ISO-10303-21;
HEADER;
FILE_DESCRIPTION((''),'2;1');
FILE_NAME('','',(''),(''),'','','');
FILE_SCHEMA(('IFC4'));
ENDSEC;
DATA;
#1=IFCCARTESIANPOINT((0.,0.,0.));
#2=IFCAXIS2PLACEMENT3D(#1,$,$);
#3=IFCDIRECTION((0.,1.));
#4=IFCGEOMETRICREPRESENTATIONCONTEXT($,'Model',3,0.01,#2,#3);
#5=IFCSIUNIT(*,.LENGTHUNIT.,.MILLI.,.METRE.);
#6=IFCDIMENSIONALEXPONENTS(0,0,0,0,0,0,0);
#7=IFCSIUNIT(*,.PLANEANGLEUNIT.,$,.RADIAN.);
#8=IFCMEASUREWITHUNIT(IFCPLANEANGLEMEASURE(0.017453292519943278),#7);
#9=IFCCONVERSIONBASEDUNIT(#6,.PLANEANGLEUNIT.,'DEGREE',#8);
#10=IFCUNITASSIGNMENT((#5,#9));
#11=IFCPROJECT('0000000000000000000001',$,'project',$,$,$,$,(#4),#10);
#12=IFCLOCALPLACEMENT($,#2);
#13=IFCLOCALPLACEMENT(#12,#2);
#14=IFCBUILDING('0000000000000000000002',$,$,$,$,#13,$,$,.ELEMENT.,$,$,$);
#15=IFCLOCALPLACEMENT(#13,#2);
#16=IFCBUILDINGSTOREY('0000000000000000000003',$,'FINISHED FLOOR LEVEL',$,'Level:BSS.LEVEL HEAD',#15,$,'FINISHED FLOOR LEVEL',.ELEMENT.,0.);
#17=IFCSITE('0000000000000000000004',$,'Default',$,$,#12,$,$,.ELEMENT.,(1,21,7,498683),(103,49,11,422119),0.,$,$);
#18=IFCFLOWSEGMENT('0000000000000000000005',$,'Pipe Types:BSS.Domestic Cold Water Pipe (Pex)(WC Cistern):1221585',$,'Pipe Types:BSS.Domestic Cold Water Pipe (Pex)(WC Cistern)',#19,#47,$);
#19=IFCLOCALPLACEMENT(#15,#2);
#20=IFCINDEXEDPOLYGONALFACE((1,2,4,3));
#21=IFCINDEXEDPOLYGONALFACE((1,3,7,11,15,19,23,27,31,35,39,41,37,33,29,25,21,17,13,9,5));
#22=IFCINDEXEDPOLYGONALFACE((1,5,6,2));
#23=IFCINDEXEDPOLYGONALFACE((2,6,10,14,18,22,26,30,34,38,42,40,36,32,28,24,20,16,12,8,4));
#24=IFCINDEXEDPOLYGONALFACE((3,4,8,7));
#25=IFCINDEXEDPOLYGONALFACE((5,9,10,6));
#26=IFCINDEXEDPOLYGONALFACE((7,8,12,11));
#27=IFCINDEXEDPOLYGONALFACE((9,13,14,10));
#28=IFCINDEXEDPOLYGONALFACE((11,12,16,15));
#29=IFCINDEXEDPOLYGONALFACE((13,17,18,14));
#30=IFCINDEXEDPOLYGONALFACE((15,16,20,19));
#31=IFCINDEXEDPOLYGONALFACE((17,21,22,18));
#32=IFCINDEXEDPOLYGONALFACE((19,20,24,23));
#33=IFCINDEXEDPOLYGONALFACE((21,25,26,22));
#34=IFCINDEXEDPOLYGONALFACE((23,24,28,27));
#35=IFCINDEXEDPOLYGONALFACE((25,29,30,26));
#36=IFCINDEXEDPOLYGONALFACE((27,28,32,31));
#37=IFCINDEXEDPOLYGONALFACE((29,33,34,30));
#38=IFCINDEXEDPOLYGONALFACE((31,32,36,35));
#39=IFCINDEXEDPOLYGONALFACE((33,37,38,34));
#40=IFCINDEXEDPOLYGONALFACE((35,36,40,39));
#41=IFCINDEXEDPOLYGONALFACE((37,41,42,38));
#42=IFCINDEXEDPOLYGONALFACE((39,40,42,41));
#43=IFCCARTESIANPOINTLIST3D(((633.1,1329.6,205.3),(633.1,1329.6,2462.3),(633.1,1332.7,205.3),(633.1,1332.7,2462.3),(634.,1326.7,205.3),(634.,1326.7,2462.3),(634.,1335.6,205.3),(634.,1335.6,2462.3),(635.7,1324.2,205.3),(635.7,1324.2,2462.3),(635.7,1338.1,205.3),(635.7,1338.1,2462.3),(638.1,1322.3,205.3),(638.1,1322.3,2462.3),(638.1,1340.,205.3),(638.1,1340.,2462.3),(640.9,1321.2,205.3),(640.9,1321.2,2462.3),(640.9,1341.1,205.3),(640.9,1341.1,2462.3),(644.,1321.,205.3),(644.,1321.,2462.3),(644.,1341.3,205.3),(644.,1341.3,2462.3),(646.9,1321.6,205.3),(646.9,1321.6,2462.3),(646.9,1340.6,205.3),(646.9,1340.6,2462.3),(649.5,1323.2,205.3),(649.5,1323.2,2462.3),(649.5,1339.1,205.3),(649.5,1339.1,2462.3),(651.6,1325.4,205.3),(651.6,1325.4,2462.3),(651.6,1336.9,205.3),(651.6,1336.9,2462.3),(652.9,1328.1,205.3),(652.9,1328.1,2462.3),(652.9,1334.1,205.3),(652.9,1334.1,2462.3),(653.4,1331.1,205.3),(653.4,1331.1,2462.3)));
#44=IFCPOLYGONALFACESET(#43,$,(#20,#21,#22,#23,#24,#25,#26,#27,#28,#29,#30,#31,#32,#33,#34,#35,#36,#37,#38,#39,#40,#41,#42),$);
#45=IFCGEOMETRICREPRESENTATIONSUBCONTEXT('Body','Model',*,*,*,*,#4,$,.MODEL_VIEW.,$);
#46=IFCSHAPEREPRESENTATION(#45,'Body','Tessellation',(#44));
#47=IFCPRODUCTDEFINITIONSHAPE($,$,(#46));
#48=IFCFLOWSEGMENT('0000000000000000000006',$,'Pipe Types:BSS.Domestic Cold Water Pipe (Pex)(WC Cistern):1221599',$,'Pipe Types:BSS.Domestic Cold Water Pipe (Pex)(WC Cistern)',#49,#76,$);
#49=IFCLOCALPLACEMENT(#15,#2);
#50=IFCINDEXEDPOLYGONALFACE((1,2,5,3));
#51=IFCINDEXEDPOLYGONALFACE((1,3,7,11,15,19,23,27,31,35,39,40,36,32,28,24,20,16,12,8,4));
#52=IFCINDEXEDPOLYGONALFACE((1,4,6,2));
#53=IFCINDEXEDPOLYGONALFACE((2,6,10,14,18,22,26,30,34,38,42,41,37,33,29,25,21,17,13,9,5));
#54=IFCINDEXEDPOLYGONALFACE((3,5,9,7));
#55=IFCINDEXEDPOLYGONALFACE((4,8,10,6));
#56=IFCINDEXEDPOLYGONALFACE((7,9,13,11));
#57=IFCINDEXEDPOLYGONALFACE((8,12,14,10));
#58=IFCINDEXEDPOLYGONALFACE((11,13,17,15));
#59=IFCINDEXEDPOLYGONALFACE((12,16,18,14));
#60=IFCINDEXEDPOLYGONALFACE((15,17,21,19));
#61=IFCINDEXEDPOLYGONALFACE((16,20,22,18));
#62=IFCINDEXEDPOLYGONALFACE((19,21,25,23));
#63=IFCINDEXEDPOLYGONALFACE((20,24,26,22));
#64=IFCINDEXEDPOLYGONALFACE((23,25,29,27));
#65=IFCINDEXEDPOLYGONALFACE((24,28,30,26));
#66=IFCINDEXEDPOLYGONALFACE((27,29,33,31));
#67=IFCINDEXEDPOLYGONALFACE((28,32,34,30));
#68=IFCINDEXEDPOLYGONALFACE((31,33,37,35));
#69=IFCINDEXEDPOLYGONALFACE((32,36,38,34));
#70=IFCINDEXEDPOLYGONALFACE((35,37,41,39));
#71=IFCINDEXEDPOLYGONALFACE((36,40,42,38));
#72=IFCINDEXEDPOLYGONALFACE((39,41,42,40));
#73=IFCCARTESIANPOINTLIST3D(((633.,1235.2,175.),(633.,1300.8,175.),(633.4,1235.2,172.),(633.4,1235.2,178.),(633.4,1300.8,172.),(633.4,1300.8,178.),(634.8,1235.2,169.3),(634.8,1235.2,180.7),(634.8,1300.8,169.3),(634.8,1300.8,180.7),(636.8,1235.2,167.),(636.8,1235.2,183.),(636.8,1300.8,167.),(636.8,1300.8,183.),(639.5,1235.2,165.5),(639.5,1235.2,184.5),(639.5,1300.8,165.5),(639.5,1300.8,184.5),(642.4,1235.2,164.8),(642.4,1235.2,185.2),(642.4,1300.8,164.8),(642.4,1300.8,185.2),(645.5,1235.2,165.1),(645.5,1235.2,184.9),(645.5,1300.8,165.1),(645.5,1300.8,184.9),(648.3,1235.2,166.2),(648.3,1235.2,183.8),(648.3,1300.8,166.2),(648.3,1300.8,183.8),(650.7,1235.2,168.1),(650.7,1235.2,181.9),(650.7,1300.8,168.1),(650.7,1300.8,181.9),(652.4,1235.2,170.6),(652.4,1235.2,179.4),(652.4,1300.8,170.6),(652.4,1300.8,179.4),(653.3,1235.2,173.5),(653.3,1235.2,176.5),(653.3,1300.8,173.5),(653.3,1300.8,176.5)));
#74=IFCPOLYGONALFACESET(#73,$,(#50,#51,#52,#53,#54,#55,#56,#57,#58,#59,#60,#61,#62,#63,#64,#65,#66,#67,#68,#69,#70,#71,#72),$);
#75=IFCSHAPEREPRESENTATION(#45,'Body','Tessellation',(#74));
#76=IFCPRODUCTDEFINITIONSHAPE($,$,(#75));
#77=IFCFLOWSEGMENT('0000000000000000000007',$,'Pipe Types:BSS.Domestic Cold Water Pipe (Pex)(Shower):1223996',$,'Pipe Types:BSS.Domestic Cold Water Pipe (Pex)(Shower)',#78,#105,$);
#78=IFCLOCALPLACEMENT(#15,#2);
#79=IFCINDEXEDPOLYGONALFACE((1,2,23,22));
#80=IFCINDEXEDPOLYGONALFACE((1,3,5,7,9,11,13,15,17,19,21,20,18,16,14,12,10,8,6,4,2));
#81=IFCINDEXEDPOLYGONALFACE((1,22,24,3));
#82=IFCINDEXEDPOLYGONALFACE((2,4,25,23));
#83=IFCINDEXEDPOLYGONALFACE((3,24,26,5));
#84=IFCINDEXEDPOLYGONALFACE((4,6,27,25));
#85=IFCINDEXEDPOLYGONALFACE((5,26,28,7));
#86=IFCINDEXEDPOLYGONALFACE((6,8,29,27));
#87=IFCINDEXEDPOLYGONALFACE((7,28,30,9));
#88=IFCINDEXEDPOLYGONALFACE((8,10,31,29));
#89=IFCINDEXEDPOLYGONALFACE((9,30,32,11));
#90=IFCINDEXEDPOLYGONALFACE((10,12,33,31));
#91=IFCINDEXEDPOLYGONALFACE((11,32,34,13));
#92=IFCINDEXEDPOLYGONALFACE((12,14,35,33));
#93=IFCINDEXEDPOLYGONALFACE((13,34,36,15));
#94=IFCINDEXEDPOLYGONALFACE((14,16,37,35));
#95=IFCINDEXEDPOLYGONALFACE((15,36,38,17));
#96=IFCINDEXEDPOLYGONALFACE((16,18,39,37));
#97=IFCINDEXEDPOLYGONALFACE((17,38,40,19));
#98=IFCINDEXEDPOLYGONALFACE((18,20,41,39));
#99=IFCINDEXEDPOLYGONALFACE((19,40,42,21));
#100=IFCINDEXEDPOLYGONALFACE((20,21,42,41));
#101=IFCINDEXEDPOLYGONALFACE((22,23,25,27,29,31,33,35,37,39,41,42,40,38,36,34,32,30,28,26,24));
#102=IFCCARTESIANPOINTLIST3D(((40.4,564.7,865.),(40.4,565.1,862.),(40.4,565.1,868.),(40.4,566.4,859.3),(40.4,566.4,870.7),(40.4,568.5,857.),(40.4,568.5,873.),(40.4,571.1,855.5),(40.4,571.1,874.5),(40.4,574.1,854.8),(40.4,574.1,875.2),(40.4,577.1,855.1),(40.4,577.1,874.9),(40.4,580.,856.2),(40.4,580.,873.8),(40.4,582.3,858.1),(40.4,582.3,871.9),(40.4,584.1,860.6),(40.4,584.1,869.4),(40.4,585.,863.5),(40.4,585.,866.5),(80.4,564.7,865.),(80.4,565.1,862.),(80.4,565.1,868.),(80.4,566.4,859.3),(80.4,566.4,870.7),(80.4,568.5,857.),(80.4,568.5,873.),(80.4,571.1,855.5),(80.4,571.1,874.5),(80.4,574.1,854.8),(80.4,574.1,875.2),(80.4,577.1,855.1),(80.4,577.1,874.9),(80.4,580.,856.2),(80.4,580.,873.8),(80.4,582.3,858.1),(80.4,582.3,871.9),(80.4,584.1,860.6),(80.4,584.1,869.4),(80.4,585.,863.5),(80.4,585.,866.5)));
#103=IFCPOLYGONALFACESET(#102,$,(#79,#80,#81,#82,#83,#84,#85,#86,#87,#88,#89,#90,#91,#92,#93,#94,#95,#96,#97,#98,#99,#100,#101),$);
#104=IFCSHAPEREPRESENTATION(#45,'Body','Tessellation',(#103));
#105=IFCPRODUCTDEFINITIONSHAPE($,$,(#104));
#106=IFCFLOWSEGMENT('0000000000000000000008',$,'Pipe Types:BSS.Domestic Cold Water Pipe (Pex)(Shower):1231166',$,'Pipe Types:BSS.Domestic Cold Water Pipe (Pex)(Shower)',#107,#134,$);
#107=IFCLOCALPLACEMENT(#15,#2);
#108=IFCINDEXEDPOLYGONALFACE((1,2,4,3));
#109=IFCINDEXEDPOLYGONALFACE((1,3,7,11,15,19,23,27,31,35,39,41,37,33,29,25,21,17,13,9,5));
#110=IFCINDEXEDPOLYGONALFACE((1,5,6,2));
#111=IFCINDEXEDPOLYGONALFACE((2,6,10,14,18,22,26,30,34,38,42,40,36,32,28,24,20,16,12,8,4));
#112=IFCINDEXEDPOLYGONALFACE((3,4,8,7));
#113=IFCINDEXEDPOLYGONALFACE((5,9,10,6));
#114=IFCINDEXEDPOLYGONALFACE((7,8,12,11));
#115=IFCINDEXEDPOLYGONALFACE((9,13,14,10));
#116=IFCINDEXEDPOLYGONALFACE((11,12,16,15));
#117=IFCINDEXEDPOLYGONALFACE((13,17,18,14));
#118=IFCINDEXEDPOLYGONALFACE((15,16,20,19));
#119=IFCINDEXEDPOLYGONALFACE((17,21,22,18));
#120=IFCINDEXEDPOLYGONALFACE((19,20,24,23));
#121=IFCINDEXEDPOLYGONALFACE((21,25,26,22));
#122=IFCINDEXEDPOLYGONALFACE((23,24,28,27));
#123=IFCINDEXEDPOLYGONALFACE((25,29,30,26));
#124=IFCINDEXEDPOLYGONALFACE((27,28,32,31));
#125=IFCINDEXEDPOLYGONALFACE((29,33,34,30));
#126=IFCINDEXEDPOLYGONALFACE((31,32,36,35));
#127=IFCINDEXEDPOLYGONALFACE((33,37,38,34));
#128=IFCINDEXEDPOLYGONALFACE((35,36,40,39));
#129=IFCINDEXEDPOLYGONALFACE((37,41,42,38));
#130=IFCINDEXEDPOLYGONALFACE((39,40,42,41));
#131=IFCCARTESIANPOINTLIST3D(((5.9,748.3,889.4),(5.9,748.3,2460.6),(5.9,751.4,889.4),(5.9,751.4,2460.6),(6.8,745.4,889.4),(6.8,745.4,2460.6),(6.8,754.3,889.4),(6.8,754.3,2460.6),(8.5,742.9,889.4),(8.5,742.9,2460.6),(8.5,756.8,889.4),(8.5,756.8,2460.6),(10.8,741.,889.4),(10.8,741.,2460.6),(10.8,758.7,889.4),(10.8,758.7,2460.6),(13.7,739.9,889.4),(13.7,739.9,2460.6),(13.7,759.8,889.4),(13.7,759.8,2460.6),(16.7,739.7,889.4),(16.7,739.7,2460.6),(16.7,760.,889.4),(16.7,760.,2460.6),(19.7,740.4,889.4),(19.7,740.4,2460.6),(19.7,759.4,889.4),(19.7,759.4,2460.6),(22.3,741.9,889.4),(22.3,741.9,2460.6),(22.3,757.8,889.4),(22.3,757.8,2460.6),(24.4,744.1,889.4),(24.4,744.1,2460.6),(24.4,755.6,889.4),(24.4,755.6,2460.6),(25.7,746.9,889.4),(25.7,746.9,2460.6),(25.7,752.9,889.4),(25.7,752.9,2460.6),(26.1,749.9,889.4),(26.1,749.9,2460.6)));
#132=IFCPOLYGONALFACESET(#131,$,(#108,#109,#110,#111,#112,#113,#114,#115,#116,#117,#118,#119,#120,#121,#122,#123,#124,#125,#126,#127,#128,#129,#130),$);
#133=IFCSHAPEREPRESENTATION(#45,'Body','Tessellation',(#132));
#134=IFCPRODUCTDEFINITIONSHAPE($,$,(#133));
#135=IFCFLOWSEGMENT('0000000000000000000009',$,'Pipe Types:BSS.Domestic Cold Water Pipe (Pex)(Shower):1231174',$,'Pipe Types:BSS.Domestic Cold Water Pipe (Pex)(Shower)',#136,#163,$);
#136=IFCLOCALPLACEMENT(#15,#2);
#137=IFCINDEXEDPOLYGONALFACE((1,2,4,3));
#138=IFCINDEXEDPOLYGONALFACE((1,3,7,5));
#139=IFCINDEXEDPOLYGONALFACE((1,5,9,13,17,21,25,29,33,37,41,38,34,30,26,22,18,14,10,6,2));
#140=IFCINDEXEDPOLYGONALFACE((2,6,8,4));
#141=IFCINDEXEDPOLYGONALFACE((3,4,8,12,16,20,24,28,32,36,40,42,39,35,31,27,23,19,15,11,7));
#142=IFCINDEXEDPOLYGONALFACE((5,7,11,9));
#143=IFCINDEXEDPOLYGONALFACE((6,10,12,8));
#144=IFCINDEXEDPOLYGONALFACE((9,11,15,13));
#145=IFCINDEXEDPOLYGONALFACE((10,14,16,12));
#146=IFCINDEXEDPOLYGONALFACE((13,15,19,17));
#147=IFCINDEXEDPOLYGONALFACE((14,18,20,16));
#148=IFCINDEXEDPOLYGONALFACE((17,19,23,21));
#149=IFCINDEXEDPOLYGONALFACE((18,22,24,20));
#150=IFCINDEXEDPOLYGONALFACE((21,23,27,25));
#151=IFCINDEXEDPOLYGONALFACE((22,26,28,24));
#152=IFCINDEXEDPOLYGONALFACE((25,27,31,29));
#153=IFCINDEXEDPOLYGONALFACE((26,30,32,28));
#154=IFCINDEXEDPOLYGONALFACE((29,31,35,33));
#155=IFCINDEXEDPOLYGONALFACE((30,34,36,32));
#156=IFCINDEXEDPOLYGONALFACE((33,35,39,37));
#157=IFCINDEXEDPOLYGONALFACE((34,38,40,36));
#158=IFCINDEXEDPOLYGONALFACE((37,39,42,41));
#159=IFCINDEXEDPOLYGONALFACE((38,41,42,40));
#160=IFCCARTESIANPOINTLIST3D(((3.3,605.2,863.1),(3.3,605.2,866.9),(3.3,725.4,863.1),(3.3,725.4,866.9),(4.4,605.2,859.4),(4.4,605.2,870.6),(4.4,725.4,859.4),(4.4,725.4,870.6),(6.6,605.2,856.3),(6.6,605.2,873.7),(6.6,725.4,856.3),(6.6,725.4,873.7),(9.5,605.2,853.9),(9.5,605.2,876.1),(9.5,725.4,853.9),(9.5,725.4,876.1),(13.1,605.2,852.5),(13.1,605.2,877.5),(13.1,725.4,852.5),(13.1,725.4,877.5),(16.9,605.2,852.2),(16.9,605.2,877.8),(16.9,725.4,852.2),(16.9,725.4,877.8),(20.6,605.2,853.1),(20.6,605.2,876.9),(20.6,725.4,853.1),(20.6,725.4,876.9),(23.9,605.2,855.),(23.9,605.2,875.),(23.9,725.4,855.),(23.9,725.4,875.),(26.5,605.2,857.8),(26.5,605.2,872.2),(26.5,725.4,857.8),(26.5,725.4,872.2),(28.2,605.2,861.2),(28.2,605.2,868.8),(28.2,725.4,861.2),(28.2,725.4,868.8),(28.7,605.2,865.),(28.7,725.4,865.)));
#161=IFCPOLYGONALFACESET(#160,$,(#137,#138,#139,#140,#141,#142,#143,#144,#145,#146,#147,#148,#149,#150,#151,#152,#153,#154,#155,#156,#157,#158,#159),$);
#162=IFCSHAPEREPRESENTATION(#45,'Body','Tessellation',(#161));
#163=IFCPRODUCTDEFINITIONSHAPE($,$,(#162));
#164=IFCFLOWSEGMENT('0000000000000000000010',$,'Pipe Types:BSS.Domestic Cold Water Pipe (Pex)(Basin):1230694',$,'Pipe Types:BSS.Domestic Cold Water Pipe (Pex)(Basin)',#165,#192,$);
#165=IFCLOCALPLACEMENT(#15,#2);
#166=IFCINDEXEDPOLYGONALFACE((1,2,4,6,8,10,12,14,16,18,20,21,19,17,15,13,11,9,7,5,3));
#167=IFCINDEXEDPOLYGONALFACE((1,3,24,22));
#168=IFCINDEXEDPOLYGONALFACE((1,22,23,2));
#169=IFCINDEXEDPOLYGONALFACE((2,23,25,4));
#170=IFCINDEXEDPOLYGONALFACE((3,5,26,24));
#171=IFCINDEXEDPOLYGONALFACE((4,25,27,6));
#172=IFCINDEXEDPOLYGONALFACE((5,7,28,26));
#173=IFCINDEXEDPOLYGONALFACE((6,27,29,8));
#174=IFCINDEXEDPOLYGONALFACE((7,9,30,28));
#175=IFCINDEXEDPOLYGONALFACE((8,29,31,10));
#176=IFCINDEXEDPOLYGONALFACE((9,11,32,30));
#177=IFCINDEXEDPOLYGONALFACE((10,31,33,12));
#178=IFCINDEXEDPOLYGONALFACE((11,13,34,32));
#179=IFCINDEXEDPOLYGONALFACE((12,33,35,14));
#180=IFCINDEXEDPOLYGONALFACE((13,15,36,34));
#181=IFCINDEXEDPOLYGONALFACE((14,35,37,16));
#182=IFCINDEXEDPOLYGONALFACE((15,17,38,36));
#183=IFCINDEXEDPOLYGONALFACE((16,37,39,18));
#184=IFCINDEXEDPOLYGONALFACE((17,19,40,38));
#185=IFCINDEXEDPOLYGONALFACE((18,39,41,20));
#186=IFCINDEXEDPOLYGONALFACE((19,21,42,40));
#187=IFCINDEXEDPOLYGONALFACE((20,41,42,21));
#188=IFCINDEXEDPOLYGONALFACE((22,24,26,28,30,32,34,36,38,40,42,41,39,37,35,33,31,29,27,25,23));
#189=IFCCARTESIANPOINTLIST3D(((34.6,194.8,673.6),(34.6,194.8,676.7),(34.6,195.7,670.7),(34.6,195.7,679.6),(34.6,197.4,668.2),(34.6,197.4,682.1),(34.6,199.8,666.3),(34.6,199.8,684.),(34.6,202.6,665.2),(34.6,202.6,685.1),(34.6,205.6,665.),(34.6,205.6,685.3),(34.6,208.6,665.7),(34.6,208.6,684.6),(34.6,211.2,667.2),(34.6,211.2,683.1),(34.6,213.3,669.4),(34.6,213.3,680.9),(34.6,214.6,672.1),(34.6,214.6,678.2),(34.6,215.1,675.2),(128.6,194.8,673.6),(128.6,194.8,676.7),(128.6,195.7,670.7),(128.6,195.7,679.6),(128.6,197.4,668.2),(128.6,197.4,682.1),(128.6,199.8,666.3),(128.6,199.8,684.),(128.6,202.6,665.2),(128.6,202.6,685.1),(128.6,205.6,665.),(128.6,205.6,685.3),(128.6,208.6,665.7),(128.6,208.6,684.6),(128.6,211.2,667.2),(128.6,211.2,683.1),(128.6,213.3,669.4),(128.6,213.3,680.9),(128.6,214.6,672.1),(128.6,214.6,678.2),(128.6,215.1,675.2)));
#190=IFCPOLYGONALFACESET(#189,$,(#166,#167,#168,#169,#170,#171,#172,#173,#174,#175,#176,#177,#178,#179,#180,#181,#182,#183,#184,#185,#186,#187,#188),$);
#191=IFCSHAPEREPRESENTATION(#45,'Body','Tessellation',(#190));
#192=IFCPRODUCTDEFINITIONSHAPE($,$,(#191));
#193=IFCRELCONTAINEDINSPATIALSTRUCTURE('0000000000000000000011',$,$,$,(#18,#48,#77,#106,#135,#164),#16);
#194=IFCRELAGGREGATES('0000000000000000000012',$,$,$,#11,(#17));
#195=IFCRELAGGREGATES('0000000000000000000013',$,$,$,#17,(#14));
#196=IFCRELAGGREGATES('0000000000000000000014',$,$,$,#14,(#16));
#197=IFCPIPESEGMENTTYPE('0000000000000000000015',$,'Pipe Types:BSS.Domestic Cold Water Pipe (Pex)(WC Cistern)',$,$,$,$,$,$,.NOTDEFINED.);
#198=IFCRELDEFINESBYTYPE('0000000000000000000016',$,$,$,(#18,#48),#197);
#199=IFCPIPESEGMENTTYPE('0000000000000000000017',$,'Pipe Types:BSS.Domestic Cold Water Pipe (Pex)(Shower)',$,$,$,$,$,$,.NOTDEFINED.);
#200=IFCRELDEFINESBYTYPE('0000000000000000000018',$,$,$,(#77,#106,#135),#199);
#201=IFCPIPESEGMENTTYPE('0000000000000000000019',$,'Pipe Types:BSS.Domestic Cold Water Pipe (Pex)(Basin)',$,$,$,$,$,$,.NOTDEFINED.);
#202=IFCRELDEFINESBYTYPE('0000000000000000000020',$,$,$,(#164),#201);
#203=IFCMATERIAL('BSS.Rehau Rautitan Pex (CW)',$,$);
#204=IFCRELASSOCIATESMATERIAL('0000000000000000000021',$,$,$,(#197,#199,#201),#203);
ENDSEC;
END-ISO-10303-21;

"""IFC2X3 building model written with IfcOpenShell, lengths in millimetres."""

from ifc_helpers import new_model, entity, si_unit, converted_unit, direction, frame, frame_2d, origin, origin_2d_with_axis, place, context, subcontext, project, spatial, circle, extrude, material, type_object, element, save


model = new_model("IFC2X3")

# Units and contexts
model_context = context("Model", 3, precision=0.01, world=origin(), true_north=direction((0.0, 1.0)))
body_context = subcontext(model_context, "Body", "Model", "MODEL_VIEW")
ifc_project = project(units=[si_unit("LENGTHUNIT", "METRE", prefix="MILLI"), converted_unit("PLANEANGLEUNIT", "DEGREE", entity("IfcPlaneAngleMeasure", 0.017453292519943278), si_unit("PLANEANGLEUNIT", "RADIAN"), dimensions=[0, 0, 0, 0, 0, 0, 0])], contexts=[model_context])

# Site, building, storey
site_placement = place(None, origin())
site = spatial("IfcSite", under=ifc_project, at=site_placement, Name="Default", CompositionType="ELEMENT", RefLatitude=(1, 21, 7, 498683), RefLongitude=(103, 49, 11, 422119), RefElevation=0.0)
building_placement = place(site_placement, origin())
building = spatial("IfcBuilding", under=site, at=building_placement, CompositionType="ELEMENT")
storey_placement = place(building_placement, origin())
storey = spatial("IfcBuildingStorey", under=building, at=storey_placement, Name="FINISHED FLOOR LEVEL", ObjectType="Level:BSS.LEVEL HEAD", LongName="FINISHED FLOOR LEVEL", CompositionType="ELEMENT", Elevation=0.0)

# Flow segments
ifc_material_1 = material(Name="BSS.Rehau Rautitan Pex (CW)")
pipe_segment_type_1 = type_object("IfcPipeSegmentType", Name="Pipe Types:BSS.Domestic Cold Water Pipe (Pex)(WC Cistern)", PredefinedType="NOTDEFINED", material=ifc_material_1)
flow_segment_1_placement = place(storey_placement, origin())
element("IfcFlowSegment", 1, at=flow_segment_1_placement, inside=storey, type_object=pipe_segment_type_1, Name="Pipe Types:BSS.Domestic Cold Water Pipe (Pex)(WC Cistern):1221585", ObjectType="Pipe Types:BSS.Domestic Cold Water Pipe (Pex)(WC Cistern)", context=body_context, shape_type="SweptSolid", body=[
    extrude(circle(Radius=10.2, at=frame_2d((0.0, 0.0), x_axis=(1.0, 0.0))), frame((643.2, 1331.1, 205.3)), (0.0, 0.0, 1.0), 2257.0),
])
flow_segment_2_placement = place(storey_placement, origin())
element("IfcFlowSegment", 2, at=flow_segment_2_placement, inside=storey, type_object=pipe_segment_type_1, Name="Pipe Types:BSS.Domestic Cold Water Pipe (Pex)(WC Cistern):1221599", ObjectType="Pipe Types:BSS.Domestic Cold Water Pipe (Pex)(WC Cistern)", context=body_context, shape_type="SweptSolid", body=[
    extrude(circle(Radius=10.2, at=frame_2d((0.0, 0.0), x_axis=(1.0, 0.0))), frame((643.2, 1235.2, 175.0), z_axis=(0.0, 1.0, 0.0), x_axis=(-1.0, 0.0, 0.0)), (0.0, 0.0, 1.0), 65.6),
])
pipe_segment_type_2 = type_object("IfcPipeSegmentType", Name="Pipe Types:BSS.Domestic Cold Water Pipe (Pex)(Shower)", PredefinedType="NOTDEFINED", material=ifc_material_1)
flow_segment_3_placement = place(storey_placement, origin())
element("IfcFlowSegment", 3, at=flow_segment_3_placement, inside=storey, type_object=pipe_segment_type_2, Name="Pipe Types:BSS.Domestic Cold Water Pipe (Pex)(Shower):1223996", ObjectType="Pipe Types:BSS.Domestic Cold Water Pipe (Pex)(Shower)", context=body_context, shape_type="SweptSolid", body=[
    extrude(circle(Radius=10.2, at=frame_2d((0.0, 0.0), x_axis=(1.0, 0.0))), frame((40.4, 574.9, 865.0), z_axis=(1.0, 0.0, 0.0), x_axis=(0.0, -1.0, 0.0)), (0.0, 0.0, 1.0), 40.0),
])
flow_segment_4_placement = place(storey_placement, origin())
element("IfcFlowSegment", 4, at=flow_segment_4_placement, inside=storey, type_object=pipe_segment_type_2, Name="Pipe Types:BSS.Domestic Cold Water Pipe (Pex)(Shower):1231166", ObjectType="Pipe Types:BSS.Domestic Cold Water Pipe (Pex)(Shower)", context=body_context, shape_type="SweptSolid", body=[
    extrude(circle(Radius=10.2, at=frame_2d((0.0, 0.0), x_axis=(1.0, 0.0))), frame((15.9, 749.9, 889.4)), (0.0, 0.0, 1.0), 1571.1),
])
flow_segment_5_placement = place(storey_placement, origin())
element("IfcFlowSegment", 5, at=flow_segment_5_placement, inside=storey, type_object=pipe_segment_type_2, Name="Pipe Types:BSS.Domestic Cold Water Pipe (Pex)(Shower):1231174", ObjectType="Pipe Types:BSS.Domestic Cold Water Pipe (Pex)(Shower)", context=body_context, shape_type="SweptSolid", body=[
    extrude(circle(Radius=12.8, at=frame_2d((0.0, 0.0), x_axis=(1.0, 0.0))), frame((15.9, 605.2, 865.0), z_axis=(0.0, 1.0, 0.0), x_axis=(1.0, 0.0, 0.0)), (0.0, 0.0, 1.0), 120.2),
])
pipe_segment_type_3 = type_object("IfcPipeSegmentType", Name="Pipe Types:BSS.Domestic Cold Water Pipe (Pex)(Basin)", PredefinedType="NOTDEFINED", material=ifc_material_1)
flow_segment_6_placement = place(storey_placement, origin())
element("IfcFlowSegment", 6, at=flow_segment_6_placement, inside=storey, type_object=pipe_segment_type_3, Name="Pipe Types:BSS.Domestic Cold Water Pipe (Pex)(Basin):1230694", ObjectType="Pipe Types:BSS.Domestic Cold Water Pipe (Pex)(Basin)", context=body_context, shape_type="SweptSolid", body=[
    extrude(circle(Radius=10.2, at=origin_2d_with_axis()), frame((34.6, 204.9, 675.2), z_axis=(1.0, 0.0, 0.0), x_axis=(0.0, 1.0, 0.0)), (0.0, 0.0, 1.0), 94.0),
])

save(model, "model.ifc")
